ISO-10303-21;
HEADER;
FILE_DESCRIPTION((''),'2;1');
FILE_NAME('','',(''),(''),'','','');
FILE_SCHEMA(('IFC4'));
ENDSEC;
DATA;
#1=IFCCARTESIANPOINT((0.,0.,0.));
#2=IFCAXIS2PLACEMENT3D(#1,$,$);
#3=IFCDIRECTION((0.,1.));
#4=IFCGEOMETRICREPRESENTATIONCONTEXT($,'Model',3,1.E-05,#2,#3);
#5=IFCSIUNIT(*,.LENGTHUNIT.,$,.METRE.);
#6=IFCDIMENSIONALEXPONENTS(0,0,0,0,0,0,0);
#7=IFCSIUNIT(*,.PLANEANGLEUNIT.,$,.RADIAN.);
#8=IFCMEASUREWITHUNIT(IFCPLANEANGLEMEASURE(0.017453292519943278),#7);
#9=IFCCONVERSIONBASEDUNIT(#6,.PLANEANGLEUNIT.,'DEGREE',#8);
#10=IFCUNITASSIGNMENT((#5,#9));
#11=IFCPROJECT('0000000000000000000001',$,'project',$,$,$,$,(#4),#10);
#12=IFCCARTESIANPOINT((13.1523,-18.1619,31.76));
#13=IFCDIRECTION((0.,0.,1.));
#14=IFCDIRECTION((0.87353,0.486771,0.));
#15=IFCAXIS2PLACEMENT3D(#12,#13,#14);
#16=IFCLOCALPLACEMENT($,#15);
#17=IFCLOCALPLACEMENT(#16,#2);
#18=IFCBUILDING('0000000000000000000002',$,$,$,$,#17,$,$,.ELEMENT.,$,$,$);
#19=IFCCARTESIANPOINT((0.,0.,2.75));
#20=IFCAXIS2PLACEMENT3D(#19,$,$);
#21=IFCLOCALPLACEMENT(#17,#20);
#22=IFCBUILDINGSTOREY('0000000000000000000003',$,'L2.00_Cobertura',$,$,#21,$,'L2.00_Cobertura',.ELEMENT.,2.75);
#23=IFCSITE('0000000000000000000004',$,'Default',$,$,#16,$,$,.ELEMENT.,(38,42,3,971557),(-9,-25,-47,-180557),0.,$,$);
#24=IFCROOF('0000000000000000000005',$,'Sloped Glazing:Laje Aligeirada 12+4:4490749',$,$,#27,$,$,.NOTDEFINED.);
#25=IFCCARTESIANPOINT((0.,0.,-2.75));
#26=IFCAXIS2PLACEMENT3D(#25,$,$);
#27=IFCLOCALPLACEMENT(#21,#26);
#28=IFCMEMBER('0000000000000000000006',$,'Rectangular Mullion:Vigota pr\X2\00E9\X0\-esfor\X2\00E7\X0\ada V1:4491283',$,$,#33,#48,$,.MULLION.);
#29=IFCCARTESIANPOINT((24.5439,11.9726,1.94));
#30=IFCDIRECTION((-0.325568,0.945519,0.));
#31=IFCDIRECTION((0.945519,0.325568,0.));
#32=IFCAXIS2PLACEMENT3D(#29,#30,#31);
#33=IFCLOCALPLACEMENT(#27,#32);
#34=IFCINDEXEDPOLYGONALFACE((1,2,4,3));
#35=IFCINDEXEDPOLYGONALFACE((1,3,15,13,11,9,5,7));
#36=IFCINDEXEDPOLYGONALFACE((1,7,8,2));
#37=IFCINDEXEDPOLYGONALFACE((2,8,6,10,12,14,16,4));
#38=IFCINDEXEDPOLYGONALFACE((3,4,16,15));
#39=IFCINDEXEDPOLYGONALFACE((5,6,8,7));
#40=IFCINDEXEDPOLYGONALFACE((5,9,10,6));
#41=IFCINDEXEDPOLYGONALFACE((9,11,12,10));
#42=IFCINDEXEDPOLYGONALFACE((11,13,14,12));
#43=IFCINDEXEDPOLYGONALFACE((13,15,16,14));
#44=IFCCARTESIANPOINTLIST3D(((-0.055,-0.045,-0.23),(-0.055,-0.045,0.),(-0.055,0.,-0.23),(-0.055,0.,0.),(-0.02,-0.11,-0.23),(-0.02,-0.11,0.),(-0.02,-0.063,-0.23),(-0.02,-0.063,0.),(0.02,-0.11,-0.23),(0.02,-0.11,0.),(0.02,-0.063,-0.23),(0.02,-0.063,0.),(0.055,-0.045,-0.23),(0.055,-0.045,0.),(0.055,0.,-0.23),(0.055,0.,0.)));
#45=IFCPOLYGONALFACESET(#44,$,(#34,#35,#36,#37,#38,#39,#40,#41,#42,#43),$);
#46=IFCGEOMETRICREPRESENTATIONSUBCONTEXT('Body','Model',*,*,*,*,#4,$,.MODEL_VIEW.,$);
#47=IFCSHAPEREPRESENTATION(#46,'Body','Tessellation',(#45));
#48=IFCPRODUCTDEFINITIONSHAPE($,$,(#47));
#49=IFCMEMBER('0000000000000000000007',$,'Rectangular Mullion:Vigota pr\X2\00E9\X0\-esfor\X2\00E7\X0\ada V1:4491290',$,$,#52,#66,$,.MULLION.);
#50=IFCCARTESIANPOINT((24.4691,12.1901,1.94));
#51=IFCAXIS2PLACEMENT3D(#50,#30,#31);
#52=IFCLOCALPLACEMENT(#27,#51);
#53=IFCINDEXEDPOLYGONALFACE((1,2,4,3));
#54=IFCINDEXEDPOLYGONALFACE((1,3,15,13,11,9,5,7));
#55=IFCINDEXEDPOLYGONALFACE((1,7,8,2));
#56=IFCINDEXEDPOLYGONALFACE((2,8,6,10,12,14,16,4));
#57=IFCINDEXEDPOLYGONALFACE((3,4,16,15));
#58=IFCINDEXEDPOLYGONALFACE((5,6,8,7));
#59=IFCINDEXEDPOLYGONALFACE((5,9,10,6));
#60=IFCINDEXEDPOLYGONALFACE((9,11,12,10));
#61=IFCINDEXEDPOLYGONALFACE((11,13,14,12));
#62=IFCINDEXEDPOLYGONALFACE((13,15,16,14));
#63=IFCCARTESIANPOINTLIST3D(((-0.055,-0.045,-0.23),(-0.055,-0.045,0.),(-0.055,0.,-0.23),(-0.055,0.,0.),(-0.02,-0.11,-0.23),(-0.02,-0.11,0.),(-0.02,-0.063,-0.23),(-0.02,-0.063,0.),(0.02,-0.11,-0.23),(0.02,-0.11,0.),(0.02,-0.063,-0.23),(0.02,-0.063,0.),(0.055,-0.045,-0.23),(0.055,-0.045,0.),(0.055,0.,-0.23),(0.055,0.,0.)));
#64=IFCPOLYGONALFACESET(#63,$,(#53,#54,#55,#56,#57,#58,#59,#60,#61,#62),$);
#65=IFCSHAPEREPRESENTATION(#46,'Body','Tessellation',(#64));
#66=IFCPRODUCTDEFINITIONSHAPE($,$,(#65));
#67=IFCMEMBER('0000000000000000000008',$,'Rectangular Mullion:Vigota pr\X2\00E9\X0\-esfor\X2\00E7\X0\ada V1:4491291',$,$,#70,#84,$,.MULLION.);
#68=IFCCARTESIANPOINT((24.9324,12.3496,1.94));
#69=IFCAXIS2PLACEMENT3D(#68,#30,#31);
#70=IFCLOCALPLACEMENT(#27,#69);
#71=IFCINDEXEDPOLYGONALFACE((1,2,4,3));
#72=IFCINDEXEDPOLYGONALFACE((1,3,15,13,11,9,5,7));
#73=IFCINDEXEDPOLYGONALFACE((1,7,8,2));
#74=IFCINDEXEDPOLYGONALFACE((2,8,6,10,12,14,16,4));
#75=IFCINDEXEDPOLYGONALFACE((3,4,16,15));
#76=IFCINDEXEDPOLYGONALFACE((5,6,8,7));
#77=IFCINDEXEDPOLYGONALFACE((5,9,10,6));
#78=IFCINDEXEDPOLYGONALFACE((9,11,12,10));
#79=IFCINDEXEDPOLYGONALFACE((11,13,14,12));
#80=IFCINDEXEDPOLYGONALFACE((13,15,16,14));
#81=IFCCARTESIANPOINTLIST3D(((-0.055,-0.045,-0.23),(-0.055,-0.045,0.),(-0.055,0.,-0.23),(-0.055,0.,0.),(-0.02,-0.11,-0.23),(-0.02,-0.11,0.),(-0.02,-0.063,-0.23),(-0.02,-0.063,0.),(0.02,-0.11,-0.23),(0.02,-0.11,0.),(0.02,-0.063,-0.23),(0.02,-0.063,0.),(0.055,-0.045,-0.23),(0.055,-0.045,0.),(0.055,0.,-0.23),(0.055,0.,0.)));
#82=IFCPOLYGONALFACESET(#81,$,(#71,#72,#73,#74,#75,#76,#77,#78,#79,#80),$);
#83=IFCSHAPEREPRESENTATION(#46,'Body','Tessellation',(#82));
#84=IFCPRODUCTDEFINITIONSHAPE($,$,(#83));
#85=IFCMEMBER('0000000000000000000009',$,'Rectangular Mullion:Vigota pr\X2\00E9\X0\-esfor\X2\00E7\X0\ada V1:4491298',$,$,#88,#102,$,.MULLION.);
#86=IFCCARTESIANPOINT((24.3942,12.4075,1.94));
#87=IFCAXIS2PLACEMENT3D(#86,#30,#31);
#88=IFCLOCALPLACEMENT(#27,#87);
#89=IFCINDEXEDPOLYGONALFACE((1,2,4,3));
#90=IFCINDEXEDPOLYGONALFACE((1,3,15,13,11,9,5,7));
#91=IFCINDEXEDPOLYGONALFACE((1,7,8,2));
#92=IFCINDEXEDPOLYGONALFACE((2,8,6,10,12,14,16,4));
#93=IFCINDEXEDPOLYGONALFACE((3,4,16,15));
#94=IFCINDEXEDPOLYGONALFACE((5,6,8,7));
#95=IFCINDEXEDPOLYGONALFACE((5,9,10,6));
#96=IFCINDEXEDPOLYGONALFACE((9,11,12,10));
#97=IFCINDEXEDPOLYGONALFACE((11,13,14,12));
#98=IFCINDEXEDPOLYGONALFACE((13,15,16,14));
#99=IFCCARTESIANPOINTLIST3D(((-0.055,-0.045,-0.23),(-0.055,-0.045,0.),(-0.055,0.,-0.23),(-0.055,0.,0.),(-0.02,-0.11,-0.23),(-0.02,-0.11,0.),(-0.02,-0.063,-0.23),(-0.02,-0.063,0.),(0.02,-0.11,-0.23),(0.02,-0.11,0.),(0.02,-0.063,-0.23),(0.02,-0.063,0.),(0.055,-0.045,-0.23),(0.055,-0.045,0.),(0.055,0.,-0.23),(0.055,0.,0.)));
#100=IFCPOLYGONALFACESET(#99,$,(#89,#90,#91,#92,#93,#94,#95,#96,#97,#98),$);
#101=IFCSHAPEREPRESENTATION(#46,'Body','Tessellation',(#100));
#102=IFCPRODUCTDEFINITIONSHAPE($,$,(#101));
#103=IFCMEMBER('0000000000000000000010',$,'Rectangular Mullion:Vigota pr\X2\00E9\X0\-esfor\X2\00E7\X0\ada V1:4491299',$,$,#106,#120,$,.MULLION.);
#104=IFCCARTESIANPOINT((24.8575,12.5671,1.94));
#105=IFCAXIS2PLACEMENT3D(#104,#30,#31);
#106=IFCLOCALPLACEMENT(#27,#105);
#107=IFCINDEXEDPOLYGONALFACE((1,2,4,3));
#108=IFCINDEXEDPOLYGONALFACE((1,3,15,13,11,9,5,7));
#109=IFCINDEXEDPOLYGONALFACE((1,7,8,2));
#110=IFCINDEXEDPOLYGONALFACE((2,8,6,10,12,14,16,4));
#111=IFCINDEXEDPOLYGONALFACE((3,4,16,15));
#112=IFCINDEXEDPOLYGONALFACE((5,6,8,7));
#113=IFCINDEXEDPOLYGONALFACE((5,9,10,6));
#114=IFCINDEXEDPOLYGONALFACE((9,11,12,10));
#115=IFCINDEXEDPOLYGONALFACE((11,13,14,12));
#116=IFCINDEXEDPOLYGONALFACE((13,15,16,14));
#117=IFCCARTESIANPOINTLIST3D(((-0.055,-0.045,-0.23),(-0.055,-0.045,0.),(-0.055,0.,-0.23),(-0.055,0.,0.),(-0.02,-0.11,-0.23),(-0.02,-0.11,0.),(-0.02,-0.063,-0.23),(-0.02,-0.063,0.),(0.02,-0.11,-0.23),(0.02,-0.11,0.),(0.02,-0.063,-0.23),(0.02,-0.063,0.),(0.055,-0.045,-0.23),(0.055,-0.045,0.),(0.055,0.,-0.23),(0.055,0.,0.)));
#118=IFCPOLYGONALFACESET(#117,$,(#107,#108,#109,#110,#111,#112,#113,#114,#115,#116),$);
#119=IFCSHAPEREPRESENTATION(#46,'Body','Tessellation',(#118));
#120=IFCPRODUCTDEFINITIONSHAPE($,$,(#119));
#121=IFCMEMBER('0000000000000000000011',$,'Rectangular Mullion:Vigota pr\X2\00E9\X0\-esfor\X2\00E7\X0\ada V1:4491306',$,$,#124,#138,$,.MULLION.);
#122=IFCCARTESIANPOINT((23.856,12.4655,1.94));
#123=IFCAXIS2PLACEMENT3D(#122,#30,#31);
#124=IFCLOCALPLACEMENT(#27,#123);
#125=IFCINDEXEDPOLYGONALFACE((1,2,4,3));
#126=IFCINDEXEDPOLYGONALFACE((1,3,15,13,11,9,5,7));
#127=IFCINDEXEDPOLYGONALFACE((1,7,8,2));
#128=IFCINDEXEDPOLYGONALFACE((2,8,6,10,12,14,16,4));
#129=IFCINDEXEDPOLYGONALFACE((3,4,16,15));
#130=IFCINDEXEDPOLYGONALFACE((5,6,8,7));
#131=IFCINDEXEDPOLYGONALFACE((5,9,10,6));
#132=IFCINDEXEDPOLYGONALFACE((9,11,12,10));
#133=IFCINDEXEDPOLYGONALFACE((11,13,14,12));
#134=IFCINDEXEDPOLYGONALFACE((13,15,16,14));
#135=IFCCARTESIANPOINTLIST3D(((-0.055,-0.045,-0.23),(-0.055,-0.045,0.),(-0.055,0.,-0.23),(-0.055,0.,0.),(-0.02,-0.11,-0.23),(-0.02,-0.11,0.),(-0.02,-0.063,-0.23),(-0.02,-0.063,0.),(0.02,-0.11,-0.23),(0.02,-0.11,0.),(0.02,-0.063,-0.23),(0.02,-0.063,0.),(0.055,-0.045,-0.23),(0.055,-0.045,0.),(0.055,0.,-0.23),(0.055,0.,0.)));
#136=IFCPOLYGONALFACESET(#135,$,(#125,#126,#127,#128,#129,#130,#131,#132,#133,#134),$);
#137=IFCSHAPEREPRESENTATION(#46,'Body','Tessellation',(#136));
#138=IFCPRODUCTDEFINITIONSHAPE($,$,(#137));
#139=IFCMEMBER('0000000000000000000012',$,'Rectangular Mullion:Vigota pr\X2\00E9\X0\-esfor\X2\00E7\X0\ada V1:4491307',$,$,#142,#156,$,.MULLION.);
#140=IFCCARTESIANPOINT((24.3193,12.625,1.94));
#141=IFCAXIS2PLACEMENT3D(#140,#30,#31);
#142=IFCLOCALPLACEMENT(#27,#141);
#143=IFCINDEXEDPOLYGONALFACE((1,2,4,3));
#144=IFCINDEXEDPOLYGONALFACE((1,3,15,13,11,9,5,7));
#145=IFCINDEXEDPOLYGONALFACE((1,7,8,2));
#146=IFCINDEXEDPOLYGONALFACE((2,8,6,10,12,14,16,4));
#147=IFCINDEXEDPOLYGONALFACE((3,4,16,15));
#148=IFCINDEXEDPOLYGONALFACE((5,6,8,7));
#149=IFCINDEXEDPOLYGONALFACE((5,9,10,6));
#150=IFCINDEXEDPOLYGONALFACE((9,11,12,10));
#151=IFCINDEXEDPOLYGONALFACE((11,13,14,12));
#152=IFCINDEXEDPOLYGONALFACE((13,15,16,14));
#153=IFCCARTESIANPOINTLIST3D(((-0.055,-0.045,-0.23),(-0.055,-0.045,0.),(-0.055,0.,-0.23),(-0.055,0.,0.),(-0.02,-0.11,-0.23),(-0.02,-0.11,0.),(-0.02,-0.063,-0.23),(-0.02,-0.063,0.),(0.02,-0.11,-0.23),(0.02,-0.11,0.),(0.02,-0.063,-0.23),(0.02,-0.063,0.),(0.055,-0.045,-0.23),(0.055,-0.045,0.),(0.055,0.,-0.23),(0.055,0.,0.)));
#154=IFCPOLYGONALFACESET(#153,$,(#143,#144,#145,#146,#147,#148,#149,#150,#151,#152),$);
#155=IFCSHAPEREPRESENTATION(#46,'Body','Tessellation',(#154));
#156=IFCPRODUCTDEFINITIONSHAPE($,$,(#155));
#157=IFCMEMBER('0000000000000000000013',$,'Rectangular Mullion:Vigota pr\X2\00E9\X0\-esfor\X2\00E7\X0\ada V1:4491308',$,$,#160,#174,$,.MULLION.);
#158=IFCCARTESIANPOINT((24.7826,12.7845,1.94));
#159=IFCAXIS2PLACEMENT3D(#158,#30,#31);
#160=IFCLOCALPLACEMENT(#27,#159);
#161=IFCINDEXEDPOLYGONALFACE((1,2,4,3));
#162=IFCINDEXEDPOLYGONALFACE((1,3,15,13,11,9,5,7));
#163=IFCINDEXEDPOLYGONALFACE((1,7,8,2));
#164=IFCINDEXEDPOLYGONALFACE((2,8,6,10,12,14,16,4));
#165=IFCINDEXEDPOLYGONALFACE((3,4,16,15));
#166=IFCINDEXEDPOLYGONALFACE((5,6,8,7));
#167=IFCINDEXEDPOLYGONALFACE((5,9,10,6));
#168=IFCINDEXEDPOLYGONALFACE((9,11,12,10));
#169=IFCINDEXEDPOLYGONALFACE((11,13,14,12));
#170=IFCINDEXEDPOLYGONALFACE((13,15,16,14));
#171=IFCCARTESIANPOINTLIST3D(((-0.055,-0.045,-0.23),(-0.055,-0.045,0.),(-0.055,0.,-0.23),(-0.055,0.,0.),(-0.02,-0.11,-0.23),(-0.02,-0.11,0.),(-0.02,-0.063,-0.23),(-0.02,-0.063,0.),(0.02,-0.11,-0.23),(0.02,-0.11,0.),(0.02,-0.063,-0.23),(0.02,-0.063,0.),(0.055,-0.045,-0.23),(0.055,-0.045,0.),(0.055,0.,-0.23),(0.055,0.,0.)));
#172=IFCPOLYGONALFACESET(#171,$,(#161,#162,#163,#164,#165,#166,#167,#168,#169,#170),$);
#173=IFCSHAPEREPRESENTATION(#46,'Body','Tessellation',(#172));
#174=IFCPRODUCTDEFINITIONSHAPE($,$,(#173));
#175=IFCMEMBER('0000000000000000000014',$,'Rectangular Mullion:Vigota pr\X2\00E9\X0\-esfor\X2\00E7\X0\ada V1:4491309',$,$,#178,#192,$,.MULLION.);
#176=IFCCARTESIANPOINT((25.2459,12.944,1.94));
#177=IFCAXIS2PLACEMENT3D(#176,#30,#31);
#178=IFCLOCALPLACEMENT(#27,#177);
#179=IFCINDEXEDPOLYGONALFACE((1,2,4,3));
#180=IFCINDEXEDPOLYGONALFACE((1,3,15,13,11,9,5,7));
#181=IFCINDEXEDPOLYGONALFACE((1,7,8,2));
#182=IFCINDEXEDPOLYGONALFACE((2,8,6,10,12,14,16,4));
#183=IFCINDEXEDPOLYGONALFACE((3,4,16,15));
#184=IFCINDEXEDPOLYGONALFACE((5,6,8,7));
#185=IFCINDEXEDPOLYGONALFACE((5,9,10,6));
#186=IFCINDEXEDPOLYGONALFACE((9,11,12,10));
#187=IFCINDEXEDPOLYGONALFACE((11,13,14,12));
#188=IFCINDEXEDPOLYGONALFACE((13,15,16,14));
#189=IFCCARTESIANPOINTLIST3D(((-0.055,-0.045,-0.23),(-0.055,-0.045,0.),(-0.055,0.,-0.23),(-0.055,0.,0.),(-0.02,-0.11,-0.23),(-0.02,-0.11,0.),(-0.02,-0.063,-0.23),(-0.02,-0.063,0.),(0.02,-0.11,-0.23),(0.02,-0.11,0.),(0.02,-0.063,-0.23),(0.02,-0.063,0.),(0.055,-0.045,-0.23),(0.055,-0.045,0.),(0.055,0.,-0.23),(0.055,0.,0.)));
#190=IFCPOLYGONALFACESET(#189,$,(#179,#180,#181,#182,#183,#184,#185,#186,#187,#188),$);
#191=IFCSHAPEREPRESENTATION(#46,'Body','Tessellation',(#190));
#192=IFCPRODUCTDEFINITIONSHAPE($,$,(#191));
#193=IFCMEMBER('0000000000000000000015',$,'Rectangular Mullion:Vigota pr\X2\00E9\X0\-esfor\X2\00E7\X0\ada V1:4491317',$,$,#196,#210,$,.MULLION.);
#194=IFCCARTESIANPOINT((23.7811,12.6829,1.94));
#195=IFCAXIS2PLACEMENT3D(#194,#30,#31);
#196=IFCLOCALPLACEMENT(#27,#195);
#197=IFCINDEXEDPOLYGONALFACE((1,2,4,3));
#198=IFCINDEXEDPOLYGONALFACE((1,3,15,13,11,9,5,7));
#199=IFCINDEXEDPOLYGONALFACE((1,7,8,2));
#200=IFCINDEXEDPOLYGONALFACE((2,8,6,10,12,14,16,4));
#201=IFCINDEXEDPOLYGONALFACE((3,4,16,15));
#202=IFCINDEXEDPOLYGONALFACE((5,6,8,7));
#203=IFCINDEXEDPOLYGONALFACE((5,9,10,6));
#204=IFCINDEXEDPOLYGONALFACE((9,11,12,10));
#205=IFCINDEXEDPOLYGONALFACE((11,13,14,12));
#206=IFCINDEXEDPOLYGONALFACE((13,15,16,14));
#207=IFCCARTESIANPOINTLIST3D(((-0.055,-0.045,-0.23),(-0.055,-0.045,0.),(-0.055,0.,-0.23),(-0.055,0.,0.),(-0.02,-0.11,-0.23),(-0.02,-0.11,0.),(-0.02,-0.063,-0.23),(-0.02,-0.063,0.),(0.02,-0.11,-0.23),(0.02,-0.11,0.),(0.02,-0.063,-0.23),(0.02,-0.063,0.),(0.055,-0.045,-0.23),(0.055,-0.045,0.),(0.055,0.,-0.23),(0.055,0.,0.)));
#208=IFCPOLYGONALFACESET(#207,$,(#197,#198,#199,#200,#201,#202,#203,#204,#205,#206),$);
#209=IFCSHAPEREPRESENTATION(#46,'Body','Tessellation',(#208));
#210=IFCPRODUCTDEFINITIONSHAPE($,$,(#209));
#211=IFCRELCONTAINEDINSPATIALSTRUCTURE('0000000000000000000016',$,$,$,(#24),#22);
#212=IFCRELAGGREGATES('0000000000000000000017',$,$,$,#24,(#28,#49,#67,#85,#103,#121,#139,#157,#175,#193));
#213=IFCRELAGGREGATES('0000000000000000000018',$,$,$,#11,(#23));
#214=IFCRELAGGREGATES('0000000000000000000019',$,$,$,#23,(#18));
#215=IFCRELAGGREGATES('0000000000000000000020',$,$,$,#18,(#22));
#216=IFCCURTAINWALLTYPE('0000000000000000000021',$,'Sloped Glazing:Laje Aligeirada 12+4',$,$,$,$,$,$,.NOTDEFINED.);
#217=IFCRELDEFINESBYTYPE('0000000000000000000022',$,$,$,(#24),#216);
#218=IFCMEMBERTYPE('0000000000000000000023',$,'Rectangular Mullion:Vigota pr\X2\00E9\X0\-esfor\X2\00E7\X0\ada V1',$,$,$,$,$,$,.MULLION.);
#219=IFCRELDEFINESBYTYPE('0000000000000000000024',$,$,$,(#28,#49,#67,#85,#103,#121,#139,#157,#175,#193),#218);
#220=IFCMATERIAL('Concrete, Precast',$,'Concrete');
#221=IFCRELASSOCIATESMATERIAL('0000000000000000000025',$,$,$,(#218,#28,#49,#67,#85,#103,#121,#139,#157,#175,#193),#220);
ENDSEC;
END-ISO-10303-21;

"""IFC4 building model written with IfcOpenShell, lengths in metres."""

from ifc_helpers import new_model, entity, si_unit, converted_unit, direction, frame, origin, place, context, subcontext, project, spatial, indexed_curve, outline, extrude, source, transform, mapped, material, type_object, type_shapes, element, aggregate, save


model = new_model("IFC4")

# Units and contexts
model_context = context("Model", 3, precision=1e-05, world=origin(), true_north=direction((0.0, 1.0)))
body_context = subcontext(model_context, "Body", "Model", "MODEL_VIEW")
ifc_project = project(units=[si_unit("LENGTHUNIT", "METRE"), converted_unit("PLANEANGLEUNIT", "DEGREE", entity("IfcPlaneAngleMeasure", 0.017453292519943278), si_unit("PLANEANGLEUNIT", "RADIAN"), dimensions=[0, 0, 0, 0, 0, 0, 0])], contexts=[model_context])

# Site, building, storey
site_placement = place(None, frame((13.1523, -18.1619, 31.76), z_axis=(0.0, 0.0, 1.0), x_axis=(0.87353, 0.486771, 0.0)))
site = spatial("IfcSite", under=ifc_project, at=site_placement, Name="Default", CompositionType="ELEMENT", RefLatitude=(38, 42, 3, 971557), RefLongitude=(-9, -25, -47, -180557), RefElevation=0.0)
building_placement = place(site_placement, origin())
building = spatial("IfcBuilding", under=site, at=building_placement, CompositionType="ELEMENT")
storey_placement = place(building_placement, frame((0.0, 0.0, 2.75)))
storey = spatial("IfcBuildingStorey", under=building, at=storey_placement, Name="L2.00_Cobertura", LongName="L2.00_Cobertura", CompositionType="ELEMENT", Elevation=2.75)

# Roof, members
curtain_wall_type = type_object("IfcCurtainWallType", Name="Sloped Glazing:Laje Aligeirada 12+4", PredefinedType="NOTDEFINED")
roof_placement = place(storey_placement, frame((0.0, 0.0, -2.75)))
roof = element("IfcRoof", 1, at=roof_placement, inside=storey, type_object=curtain_wall_type, Name="Sloped Glazing:Laje Aligeirada 12+4:4490749", PredefinedType="NOTDEFINED")
ifc_material_1 = material(Name="Concrete, Precast", Category="Concrete")
member_type = type_object("IfcMemberType", Name="Rectangular Mullion:Vigota pré-esforçada V1", PredefinedType="MULLION", material=ifc_material_1)
shared_shape_1 = source(origin(), body_context, "Body", "SweptSolid", [
    extrude(outline(indexed_curve([(-0.055, -0.0545), (0.055, -0.0545), (0.055, -0.0095), (0.02, 0.0085), (0.02, 0.0555), (-0.02, 0.0555), (-0.02, 0.0085), (-0.055, -0.0095), (-0.055, -0.0545)], self_intersect=False)), frame((0.0, -0.0545, -0.23), z_axis=(0.0, 0.0, 1.0), x_axis=(-1.0, 0.0, 0.0)), (0.0, 0.0, 1.0), 0.23),
])
type_shapes(member_type, [shared_shape_1])
member_1_placement = place(roof_placement, frame((24.5439, 11.9726, 1.94), z_axis=(-0.325568, 0.945519, 0.0), x_axis=(0.945519, 0.325568, 0.0)))
member_1 = element("IfcMember", 2, at=member_1_placement, type_object=member_type, material=ifc_material_1, Name="Rectangular Mullion:Vigota pré-esforçada V1:4491283", PredefinedType="MULLION", context=body_context, shape_type="MappedRepresentation", body=[
    mapped(shared_shape_1, transform((0.0, 0.0, 0.0), scale=1.0)),
])
member_2_placement = place(roof_placement, frame((24.4691, 12.1901, 1.94), z_axis=(-0.325568, 0.945519, 0.0), x_axis=(0.945519, 0.325568, 0.0)))
member_2 = element("IfcMember", 3, at=member_2_placement, type_object=member_type, material=ifc_material_1, Name="Rectangular Mullion:Vigota pré-esforçada V1:4491290", PredefinedType="MULLION", context=body_context, shape_type="MappedRepresentation", body=[
    mapped(shared_shape_1, transform((0.0, 0.0, 0.0), scale=1.0)),
])
member_3_placement = place(roof_placement, frame((24.9324, 12.3496, 1.94), z_axis=(-0.325568, 0.945519, 0.0), x_axis=(0.945519, 0.325568, 0.0)))
member_3 = element("IfcMember", 4, at=member_3_placement, type_object=member_type, material=ifc_material_1, Name="Rectangular Mullion:Vigota pré-esforçada V1:4491291", PredefinedType="MULLION", context=body_context, shape_type="MappedRepresentation", body=[
    mapped(shared_shape_1, transform((0.0, 0.0, 0.0), scale=1.0)),
])
member_4_placement = place(roof_placement, frame((24.3942, 12.4075, 1.94), z_axis=(-0.325568, 0.945519, 0.0), x_axis=(0.945519, 0.325568, 0.0)))
member_4 = element("IfcMember", 5, at=member_4_placement, type_object=member_type, material=ifc_material_1, Name="Rectangular Mullion:Vigota pré-esforçada V1:4491298", PredefinedType="MULLION", context=body_context, shape_type="MappedRepresentation", body=[
    mapped(shared_shape_1, transform((0.0, 0.0, 0.0), scale=1.0)),
])
member_5_placement = place(roof_placement, frame((24.8575, 12.5671, 1.94), z_axis=(-0.325568, 0.945519, 0.0), x_axis=(0.945519, 0.325568, 0.0)))
member_5 = element("IfcMember", 6, at=member_5_placement, type_object=member_type, material=ifc_material_1, Name="Rectangular Mullion:Vigota pré-esforçada V1:4491299", PredefinedType="MULLION", context=body_context, shape_type="MappedRepresentation", body=[
    mapped(shared_shape_1, transform((0.0, 0.0, 0.0), scale=1.0)),
])
member_6_placement = place(roof_placement, frame((23.856, 12.4655, 1.94), z_axis=(-0.325568, 0.945519, 0.0), x_axis=(0.945519, 0.325568, 0.0)))
member_6 = element("IfcMember", 7, at=member_6_placement, type_object=member_type, material=ifc_material_1, Name="Rectangular Mullion:Vigota pré-esforçada V1:4491306", PredefinedType="MULLION", context=body_context, shape_type="MappedRepresentation", body=[
    mapped(shared_shape_1, transform((0.0, 0.0, 0.0), scale=1.0)),
])
member_7_placement = place(roof_placement, frame((24.3193, 12.625, 1.94), z_axis=(-0.325568, 0.945519, 0.0), x_axis=(0.945519, 0.325568, 0.0)))
member_7 = element("IfcMember", 8, at=member_7_placement, type_object=member_type, material=ifc_material_1, Name="Rectangular Mullion:Vigota pré-esforçada V1:4491307", PredefinedType="MULLION", context=body_context, shape_type="MappedRepresentation", body=[
    mapped(shared_shape_1, transform((0.0, 0.0, 0.0), scale=1.0)),
])
member_8_placement = place(roof_placement, frame((24.7826, 12.7845, 1.94), z_axis=(-0.325568, 0.945519, 0.0), x_axis=(0.945519, 0.325568, 0.0)))
member_8 = element("IfcMember", 9, at=member_8_placement, type_object=member_type, material=ifc_material_1, Name="Rectangular Mullion:Vigota pré-esforçada V1:4491308", PredefinedType="MULLION", context=body_context, shape_type="MappedRepresentation", body=[
    mapped(shared_shape_1, transform((0.0, 0.0, 0.0), scale=1.0)),
])
member_9_placement = place(roof_placement, frame((25.2459, 12.944, 1.94), z_axis=(-0.325568, 0.945519, 0.0), x_axis=(0.945519, 0.325568, 0.0)))
member_9 = element("IfcMember", 10, at=member_9_placement, type_object=member_type, material=ifc_material_1, Name="Rectangular Mullion:Vigota pré-esforçada V1:4491309", PredefinedType="MULLION", context=body_context, shape_type="MappedRepresentation", body=[
    mapped(shared_shape_1, transform((0.0, 0.0, 0.0), scale=1.0)),
])
member_10_placement = place(roof_placement, frame((23.7811, 12.6829, 1.94), z_axis=(-0.325568, 0.945519, 0.0), x_axis=(0.945519, 0.325568, 0.0)))
member_10 = element("IfcMember", 11, at=member_10_placement, type_object=member_type, material=ifc_material_1, Name="Rectangular Mullion:Vigota pré-esforçada V1:4491317", PredefinedType="MULLION", context=body_context, shape_type="MappedRepresentation", body=[
    mapped(shared_shape_1, transform((0.0, 0.0, 0.0), scale=1.0)),
])
aggregate(roof, [member_1, member_2, member_3, member_4, member_5, member_6, member_7, member_8, member_9, member_10])

save(model, "model.ifc")
